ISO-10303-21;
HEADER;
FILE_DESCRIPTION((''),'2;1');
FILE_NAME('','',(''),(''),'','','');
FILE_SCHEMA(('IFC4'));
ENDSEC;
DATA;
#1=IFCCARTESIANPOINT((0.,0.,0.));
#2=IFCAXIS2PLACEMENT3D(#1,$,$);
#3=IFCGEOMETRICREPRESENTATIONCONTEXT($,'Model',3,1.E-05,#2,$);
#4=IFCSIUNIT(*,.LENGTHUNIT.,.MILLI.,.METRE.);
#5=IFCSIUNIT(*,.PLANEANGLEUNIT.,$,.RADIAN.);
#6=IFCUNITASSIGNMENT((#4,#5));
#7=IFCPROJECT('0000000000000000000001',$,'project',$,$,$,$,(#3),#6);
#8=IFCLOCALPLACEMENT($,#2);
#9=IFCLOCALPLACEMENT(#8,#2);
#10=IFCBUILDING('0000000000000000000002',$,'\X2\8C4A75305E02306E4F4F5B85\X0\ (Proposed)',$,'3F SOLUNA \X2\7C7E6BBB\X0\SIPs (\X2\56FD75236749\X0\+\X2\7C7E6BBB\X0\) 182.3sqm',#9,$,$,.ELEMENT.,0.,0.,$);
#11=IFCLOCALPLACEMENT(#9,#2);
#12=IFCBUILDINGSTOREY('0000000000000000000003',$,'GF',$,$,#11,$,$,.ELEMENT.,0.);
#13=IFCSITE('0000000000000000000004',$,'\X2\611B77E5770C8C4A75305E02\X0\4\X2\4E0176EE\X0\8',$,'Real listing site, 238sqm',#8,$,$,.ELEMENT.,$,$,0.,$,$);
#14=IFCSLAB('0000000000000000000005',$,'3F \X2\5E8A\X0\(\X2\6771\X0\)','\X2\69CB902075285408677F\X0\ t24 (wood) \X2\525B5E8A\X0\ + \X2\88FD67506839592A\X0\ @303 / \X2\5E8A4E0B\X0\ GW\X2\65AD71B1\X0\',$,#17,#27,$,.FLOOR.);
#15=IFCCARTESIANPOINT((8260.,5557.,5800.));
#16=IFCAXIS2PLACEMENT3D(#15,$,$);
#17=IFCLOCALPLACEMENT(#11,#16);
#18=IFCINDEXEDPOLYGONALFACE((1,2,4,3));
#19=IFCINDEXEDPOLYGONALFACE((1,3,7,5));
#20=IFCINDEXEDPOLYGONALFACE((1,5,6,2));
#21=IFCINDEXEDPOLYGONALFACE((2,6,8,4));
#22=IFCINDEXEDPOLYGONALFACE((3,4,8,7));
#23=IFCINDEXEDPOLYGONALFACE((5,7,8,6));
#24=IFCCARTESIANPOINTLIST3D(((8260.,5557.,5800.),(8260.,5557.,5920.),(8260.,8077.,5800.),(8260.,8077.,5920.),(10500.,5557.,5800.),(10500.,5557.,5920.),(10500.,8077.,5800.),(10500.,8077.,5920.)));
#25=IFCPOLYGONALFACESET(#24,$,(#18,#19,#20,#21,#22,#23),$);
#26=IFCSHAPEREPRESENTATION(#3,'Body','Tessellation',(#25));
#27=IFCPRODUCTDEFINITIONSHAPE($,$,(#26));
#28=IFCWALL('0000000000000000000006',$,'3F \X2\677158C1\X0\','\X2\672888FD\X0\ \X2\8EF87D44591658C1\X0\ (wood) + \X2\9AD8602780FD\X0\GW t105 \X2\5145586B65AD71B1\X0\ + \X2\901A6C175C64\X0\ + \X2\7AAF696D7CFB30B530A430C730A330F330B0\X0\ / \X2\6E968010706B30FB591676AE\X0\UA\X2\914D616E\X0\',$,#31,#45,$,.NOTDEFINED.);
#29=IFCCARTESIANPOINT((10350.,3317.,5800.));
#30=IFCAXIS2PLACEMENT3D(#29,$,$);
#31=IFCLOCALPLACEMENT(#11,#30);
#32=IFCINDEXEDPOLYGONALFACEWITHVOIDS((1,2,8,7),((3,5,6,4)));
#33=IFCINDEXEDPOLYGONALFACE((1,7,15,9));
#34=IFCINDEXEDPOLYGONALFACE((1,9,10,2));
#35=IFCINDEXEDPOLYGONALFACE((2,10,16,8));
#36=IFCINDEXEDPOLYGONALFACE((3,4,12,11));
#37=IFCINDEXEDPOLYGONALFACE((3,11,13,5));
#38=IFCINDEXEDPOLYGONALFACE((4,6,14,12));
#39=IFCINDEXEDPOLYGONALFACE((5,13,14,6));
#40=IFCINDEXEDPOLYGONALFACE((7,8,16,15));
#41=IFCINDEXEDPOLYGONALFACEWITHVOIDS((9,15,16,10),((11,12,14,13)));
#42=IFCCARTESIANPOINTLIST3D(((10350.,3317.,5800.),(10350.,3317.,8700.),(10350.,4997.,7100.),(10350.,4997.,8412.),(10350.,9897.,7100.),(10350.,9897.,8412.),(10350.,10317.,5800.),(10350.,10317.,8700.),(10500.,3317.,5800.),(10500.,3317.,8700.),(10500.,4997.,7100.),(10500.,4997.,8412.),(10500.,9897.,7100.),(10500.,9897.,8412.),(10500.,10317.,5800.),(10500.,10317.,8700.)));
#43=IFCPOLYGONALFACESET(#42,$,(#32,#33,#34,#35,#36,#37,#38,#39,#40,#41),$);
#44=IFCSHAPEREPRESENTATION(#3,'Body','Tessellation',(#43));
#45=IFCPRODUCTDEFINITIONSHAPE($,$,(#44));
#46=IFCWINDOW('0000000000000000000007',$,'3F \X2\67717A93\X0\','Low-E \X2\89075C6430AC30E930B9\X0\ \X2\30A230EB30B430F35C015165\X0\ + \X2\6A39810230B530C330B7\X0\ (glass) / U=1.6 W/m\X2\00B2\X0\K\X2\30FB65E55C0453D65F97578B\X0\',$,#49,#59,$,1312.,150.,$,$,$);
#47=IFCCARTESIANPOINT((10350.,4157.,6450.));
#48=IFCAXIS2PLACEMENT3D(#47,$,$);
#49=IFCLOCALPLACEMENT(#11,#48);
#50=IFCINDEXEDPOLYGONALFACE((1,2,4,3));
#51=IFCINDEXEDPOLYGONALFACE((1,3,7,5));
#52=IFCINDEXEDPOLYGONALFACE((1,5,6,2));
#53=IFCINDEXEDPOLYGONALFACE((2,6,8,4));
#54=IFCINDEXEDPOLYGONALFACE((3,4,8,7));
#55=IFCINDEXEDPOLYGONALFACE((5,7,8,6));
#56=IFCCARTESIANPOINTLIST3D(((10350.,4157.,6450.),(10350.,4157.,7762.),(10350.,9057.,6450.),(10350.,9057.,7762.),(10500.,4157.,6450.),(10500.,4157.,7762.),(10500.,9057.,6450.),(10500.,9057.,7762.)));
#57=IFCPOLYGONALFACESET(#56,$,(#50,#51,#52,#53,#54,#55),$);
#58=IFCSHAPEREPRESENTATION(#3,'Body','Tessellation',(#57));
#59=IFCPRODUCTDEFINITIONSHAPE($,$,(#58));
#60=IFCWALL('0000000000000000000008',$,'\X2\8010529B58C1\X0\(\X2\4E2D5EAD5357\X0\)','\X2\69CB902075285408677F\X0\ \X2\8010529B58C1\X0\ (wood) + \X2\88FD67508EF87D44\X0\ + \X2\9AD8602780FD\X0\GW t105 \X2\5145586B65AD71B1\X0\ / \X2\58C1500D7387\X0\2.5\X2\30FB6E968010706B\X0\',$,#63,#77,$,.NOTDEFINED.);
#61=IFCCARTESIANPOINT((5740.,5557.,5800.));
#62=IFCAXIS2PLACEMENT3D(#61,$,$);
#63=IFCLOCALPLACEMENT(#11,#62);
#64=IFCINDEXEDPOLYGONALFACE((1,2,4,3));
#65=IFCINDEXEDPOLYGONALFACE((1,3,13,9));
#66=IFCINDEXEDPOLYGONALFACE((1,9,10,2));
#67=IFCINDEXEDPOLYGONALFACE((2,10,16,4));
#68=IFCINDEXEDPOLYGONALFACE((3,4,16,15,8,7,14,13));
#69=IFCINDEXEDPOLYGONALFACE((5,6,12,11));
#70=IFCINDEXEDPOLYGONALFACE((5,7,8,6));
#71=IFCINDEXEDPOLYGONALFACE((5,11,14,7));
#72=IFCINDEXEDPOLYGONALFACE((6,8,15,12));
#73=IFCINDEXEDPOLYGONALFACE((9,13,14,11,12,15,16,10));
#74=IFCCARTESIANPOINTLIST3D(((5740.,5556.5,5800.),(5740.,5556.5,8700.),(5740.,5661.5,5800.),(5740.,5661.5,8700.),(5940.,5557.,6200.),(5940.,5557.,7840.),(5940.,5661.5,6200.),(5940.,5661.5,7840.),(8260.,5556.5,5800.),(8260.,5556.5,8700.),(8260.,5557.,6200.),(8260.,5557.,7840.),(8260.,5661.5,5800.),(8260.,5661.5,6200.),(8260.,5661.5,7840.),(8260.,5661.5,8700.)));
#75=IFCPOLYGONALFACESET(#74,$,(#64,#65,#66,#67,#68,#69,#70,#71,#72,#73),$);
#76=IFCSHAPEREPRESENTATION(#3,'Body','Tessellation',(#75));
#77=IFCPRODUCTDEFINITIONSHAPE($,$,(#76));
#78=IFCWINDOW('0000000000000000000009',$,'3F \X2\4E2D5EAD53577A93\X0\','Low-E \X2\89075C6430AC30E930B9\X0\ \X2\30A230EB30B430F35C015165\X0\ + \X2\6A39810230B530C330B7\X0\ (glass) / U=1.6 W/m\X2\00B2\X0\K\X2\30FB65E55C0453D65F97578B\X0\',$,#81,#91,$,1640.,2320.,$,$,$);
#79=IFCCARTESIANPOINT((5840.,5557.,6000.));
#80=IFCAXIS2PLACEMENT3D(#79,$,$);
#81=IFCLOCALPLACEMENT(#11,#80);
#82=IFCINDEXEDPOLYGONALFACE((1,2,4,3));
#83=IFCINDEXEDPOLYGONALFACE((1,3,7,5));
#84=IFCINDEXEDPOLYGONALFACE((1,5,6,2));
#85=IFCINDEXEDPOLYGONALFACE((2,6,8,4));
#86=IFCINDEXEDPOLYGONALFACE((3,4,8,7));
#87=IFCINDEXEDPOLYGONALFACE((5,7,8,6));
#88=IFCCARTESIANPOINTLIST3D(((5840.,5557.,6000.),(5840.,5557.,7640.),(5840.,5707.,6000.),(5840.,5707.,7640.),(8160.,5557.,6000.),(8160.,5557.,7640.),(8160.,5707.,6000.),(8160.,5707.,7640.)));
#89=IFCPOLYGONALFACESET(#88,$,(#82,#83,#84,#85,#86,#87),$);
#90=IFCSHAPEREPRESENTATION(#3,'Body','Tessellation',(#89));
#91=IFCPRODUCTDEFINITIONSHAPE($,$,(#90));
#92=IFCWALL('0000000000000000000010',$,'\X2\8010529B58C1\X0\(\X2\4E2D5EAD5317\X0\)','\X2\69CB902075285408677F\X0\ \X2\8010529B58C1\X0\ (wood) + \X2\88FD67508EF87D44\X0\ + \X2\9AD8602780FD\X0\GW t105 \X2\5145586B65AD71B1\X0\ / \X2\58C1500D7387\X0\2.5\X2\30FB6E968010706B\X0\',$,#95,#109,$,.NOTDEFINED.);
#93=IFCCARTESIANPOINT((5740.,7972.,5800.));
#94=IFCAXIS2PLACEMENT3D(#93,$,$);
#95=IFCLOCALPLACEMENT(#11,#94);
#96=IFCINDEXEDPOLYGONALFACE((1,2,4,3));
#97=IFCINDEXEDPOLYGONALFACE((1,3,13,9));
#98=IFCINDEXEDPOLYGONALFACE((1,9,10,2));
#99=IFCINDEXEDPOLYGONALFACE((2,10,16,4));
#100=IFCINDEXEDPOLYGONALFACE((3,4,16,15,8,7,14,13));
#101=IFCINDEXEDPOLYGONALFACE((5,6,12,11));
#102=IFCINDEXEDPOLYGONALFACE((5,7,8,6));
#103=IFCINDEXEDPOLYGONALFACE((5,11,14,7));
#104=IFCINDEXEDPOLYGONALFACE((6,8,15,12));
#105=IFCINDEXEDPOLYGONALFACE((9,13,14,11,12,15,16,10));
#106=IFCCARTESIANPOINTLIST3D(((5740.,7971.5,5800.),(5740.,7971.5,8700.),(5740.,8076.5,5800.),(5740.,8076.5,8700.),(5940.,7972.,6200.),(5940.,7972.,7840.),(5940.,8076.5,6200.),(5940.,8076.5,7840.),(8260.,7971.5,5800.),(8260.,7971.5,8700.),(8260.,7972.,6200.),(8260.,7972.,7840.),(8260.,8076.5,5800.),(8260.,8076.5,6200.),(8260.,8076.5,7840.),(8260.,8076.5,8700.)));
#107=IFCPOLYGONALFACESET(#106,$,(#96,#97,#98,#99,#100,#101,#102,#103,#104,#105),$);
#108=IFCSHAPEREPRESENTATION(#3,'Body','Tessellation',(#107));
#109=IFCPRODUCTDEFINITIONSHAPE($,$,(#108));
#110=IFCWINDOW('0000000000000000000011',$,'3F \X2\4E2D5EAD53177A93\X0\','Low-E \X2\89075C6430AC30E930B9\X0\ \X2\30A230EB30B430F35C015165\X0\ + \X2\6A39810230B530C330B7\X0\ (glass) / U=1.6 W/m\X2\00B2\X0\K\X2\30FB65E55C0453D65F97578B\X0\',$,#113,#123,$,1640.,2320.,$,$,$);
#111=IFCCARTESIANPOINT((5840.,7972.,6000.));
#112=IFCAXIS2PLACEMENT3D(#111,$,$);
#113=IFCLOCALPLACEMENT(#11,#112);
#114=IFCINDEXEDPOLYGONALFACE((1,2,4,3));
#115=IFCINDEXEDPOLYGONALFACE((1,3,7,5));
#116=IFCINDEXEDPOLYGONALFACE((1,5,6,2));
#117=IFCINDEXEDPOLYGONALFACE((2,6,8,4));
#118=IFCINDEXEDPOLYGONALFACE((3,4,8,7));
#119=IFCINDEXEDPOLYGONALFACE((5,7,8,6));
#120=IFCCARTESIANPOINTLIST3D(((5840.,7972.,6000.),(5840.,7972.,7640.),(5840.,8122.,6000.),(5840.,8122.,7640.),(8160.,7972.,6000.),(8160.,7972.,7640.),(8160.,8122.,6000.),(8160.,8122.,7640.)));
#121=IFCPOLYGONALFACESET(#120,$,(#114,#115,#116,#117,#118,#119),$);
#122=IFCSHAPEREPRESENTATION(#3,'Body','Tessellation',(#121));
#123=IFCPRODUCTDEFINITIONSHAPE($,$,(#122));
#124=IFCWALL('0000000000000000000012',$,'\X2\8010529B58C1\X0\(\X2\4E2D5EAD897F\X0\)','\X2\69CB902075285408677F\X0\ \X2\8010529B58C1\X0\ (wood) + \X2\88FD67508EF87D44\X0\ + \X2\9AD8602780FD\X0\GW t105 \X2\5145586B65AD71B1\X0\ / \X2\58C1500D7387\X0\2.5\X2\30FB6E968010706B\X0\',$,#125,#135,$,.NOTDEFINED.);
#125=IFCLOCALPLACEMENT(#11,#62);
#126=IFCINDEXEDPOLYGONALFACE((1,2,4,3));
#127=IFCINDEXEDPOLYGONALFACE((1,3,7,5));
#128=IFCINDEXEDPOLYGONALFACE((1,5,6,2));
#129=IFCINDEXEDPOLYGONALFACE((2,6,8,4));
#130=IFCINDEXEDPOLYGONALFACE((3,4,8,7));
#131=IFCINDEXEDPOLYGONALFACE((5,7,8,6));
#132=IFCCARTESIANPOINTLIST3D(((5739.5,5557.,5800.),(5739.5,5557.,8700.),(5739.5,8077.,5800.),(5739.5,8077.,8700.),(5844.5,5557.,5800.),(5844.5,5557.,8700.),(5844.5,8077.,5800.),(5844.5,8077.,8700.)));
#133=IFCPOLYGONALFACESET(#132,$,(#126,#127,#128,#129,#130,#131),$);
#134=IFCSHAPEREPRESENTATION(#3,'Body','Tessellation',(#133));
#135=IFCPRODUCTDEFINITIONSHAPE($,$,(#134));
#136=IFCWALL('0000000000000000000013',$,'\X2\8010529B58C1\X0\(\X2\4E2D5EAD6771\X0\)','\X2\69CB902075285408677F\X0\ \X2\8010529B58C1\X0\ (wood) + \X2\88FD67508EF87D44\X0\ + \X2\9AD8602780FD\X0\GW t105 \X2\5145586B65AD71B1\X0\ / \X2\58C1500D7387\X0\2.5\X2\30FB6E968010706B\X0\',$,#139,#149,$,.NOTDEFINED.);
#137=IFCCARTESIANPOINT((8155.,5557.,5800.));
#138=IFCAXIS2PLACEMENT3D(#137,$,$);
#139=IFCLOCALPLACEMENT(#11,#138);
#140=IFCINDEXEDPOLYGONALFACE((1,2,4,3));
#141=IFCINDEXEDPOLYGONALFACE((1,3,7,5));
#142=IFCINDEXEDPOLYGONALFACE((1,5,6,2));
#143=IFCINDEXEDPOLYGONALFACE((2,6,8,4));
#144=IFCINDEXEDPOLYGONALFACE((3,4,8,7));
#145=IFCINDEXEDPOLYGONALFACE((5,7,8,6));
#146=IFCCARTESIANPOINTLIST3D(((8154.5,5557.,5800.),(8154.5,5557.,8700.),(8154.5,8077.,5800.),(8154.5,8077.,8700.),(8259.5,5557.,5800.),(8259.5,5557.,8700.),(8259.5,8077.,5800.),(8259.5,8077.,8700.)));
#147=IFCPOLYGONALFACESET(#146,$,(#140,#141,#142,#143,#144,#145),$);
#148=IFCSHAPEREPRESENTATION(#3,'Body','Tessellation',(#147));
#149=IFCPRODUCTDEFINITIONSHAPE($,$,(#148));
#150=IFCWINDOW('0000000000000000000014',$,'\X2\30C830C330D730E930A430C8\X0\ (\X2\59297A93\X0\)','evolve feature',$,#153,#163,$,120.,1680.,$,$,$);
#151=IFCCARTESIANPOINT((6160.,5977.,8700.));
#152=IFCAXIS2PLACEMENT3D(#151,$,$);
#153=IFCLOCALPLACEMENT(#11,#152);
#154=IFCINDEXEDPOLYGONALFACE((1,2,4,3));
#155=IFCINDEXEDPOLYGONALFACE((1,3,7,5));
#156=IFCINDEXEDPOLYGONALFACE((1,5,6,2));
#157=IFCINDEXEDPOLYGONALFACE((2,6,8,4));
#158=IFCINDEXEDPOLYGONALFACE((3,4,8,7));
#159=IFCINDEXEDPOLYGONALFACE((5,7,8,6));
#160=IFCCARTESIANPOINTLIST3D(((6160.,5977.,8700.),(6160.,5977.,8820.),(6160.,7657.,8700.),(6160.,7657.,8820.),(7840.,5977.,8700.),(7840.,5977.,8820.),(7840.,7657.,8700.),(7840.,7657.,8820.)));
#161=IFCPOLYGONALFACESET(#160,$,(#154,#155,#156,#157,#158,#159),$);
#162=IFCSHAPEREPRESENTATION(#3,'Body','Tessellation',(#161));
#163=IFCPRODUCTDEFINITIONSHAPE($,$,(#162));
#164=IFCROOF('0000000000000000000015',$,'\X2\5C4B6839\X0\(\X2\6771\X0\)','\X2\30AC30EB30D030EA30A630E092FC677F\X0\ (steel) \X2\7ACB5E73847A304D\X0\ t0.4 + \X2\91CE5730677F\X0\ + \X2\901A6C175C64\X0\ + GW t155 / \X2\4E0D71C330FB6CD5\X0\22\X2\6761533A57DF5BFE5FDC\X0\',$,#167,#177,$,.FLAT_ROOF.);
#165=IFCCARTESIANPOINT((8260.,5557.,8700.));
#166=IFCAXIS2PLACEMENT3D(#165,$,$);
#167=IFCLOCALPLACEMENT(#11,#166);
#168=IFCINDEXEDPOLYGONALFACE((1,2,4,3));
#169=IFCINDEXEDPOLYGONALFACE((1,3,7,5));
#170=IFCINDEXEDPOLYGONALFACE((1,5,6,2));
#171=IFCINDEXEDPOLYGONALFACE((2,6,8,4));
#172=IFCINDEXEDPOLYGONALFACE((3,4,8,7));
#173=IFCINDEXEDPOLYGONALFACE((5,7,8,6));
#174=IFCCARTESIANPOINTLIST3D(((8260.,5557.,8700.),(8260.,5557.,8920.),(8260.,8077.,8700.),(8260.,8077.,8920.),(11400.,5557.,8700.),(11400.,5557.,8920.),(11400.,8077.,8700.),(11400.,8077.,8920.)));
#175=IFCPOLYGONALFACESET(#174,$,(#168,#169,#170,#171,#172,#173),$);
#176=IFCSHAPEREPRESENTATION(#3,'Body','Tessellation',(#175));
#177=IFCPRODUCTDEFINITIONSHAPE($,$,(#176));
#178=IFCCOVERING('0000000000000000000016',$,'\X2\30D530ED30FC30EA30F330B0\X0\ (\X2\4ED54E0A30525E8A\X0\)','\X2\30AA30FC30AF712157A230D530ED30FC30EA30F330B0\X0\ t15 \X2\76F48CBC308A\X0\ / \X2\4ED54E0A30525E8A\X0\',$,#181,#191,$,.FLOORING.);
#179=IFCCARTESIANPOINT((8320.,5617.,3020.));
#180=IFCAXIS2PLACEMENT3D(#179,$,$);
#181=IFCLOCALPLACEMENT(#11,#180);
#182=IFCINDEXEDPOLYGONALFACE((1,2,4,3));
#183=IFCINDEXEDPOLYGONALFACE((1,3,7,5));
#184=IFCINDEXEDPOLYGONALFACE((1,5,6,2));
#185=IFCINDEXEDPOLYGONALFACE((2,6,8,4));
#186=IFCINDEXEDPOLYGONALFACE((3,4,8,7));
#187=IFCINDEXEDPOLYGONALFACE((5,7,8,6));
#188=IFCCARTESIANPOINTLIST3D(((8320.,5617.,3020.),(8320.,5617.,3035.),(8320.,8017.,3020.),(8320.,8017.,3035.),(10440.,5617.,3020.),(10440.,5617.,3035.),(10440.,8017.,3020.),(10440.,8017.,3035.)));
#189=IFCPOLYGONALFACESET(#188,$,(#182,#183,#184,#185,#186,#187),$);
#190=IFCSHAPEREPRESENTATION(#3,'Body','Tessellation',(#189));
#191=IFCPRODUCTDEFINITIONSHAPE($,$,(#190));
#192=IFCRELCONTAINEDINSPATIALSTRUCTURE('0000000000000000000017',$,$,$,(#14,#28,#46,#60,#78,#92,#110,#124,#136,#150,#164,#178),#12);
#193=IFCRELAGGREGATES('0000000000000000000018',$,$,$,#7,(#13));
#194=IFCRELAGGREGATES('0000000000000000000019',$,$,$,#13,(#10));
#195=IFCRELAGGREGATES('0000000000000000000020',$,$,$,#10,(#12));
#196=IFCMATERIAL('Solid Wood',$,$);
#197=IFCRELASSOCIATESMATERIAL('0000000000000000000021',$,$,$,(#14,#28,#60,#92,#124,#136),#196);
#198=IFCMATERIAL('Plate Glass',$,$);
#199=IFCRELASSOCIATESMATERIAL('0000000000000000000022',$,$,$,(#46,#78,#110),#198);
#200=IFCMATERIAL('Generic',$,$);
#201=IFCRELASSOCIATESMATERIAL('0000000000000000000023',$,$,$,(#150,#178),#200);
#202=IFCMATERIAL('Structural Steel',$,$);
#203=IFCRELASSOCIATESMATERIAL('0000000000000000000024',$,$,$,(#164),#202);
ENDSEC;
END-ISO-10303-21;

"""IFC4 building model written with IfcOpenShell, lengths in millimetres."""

from ifc_helpers import new_model, si_unit, frame, frame_2d, origin, place, context, project, spatial, rectangle, extrude, material, element, fill, save


model = new_model("IFC4")

# Units and contexts
model_context = context("Model", 3, precision=1e-05, world=origin())
ifc_project = project(units=[si_unit("LENGTHUNIT", "METRE", prefix="MILLI"), si_unit("PLANEANGLEUNIT", "RADIAN")], contexts=[model_context])

# Site, building, storey
site_placement = place(None, origin())
site = spatial("IfcSite", under=ifc_project, at=site_placement, Name="愛知県豊田市4丁目8", ObjectType="Real listing site, 238sqm", CompositionType="ELEMENT", RefElevation=0.0)
building_placement = place(site_placement, origin())
building = spatial("IfcBuilding", under=site, at=building_placement, Name="豊田市の住宅 (Proposed)", ObjectType="3F SOLUNA 籾殻SIPs (国産杉+籾殻) 182.3sqm", CompositionType="ELEMENT", ElevationOfRefHeight=0.0, ElevationOfTerrain=0.0)
storey_placement = place(building_placement, origin())
storey = spatial("IfcBuildingStorey", under=building, at=storey_placement, Name="GF", CompositionType="ELEMENT", Elevation=0.0)

# Slab
ifc_material_1 = material(Name="Solid Wood")
slab_placement = place(storey_placement, frame((8260.0, 5557.0, 5800.0)))
element("IfcSlab", 1, at=slab_placement, inside=storey, material=ifc_material_1, Name="3F 床(東)", Description="構造用合板 t24 (wood) 剛床 + 製材根太 @303 / 床下 GW断熱", PredefinedType="FLOOR", context=model_context, shape_type="SweptSolid", body=[
    extrude(rectangle(XDim=2240.0, YDim=2520.0, at=frame_2d((1120.0, 1260.0))), frame((8260.0, 5557.0, 5800.0)), (0.0, 0.0, 1.0), 120.0),
])

# Walls, openings, windows
wall_1_placement = place(storey_placement, frame((10350.0, 3317.0, 5800.0)))
wall_1 = element("IfcWall", 2, at=wall_1_placement, inside=storey, material=ifc_material_1, Name="3F 東壁", Description="木製 軸組外壁 (wood) + 高性能GW t105 充填断熱 + 通気層 + 窯業系サイディング / 準耐火・外皮UA配慮", PredefinedType="NOTDEFINED", context=model_context, shape_type="SweptSolid", body=[
    extrude(rectangle(XDim=150.0, YDim=7000.0, at=frame_2d((75.0, 3500.0))), frame((10350.0, 3317.0, 5800.0)), (0.0, 0.0, 1.0), 2900.0),
])
opening_1_placement = place(storey_placement, frame((10350.0, 4157.0, 6450.0)))
opening_1 = element("IfcOpeningElement", 3, at=opening_1_placement, cuts=wall_1, PredefinedType="NOTDEFINED", context=model_context, shape_type="SweptSolid", body=[
    extrude(rectangle(XDim=150.0, YDim=4900.0, at=frame_2d((75.0, 2450.0))), frame((10350.0, 4157.0, 6450.0)), (0.0, 0.0, 1.0), 1312.0),
])
ifc_material_2 = material(Name="Plate Glass")
window_1_placement = place(storey_placement, frame((10350.0, 4157.0, 6450.0)))
window_1 = element("IfcWindow", 4, at=window_1_placement, inside=storey, material=ifc_material_2, Name="3F 東窓", Description="Low-E 複層ガラス アルゴン封入 + 樹脂サッシ (glass) / U=1.6 W/m²K・日射取得型", OverallHeight=1312.0, OverallWidth=150.0, context=model_context, shape_type="SweptSolid", body=[
    extrude(rectangle(XDim=150.0, YDim=4900.0, at=frame_2d((75.0, 2450.0))), frame((10350.0, 4157.0, 6450.0)), (0.0, 0.0, 1.0), 1312.0),
])
fill(opening_1, window_1)
wall_2_placement = place(storey_placement, frame((5740.0, 5557.0, 5800.0)))
wall_2 = element("IfcWall", 5, at=wall_2_placement, inside=storey, material=ifc_material_1, Name="耐力壁(中庭南)", Description="構造用合板 耐力壁 (wood) + 製材軸組 + 高性能GW t105 充填断熱 / 壁倍率2.5・準耐火", PredefinedType="NOTDEFINED", context=model_context, shape_type="SweptSolid", body=[
    extrude(rectangle(XDim=2520.0, YDim=105.0, at=frame_2d((1260.0, 52.0))), frame((5740.0, 5557.0, 5800.0)), (0.0, 0.0, 1.0), 2900.0),
])
opening_2_placement = place(storey_placement, frame((5840.0, 5557.0, 6000.0)))
opening_2 = element("IfcOpeningElement", 6, at=opening_2_placement, cuts=wall_2, PredefinedType="NOTDEFINED", context=model_context, shape_type="SweptSolid", body=[
    extrude(rectangle(XDim=2320.0, YDim=150.0, at=frame_2d((1160.0, 75.0))), frame((5840.0, 5557.0, 6000.0)), (0.0, 0.0, 1.0), 1640.0),
])
window_2_placement = place(storey_placement, frame((5840.0, 5557.0, 6000.0)))
window_2 = element("IfcWindow", 7, at=window_2_placement, inside=storey, material=ifc_material_2, Name="3F 中庭南窓", Description="Low-E 複層ガラス アルゴン封入 + 樹脂サッシ (glass) / U=1.6 W/m²K・日射取得型", OverallHeight=1640.0, OverallWidth=2320.0, context=model_context, shape_type="SweptSolid", body=[
    extrude(rectangle(XDim=2320.0, YDim=150.0, at=frame_2d((1160.0, 75.0))), frame((5840.0, 5557.0, 6000.0)), (0.0, 0.0, 1.0), 1640.0),
])
fill(opening_2, window_2)
wall_3_placement = place(storey_placement, frame((5740.0, 7972.0, 5800.0)))
wall_3 = element("IfcWall", 8, at=wall_3_placement, inside=storey, material=ifc_material_1, Name="耐力壁(中庭北)", Description="構造用合板 耐力壁 (wood) + 製材軸組 + 高性能GW t105 充填断熱 / 壁倍率2.5・準耐火", PredefinedType="NOTDEFINED", context=model_context, shape_type="SweptSolid", body=[
    extrude(rectangle(XDim=2520.0, YDim=105.0, at=frame_2d((1260.0, 52.0))), frame((5740.0, 7972.0, 5800.0)), (0.0, 0.0, 1.0), 2900.0),
])
opening_3_placement = place(storey_placement, frame((5840.0, 7972.0, 6000.0)))
opening_3 = element("IfcOpeningElement", 9, at=opening_3_placement, cuts=wall_3, PredefinedType="NOTDEFINED", context=model_context, shape_type="SweptSolid", body=[
    extrude(rectangle(XDim=2320.0, YDim=150.0, at=frame_2d((1160.0, 75.0))), frame((5840.0, 7972.0, 6000.0)), (0.0, 0.0, 1.0), 1640.0),
])
window_3_placement = place(storey_placement, frame((5840.0, 7972.0, 6000.0)))
window_3 = element("IfcWindow", 10, at=window_3_placement, inside=storey, material=ifc_material_2, Name="3F 中庭北窓", Description="Low-E 複層ガラス アルゴン封入 + 樹脂サッシ (glass) / U=1.6 W/m²K・日射取得型", OverallHeight=1640.0, OverallWidth=2320.0, context=model_context, shape_type="SweptSolid", body=[
    extrude(rectangle(XDim=2320.0, YDim=150.0, at=frame_2d((1160.0, 75.0))), frame((5840.0, 7972.0, 6000.0)), (0.0, 0.0, 1.0), 1640.0),
])
fill(opening_3, window_3)

# Walls
wall_4_placement = place(storey_placement, frame((5740.0, 5557.0, 5800.0)))
element("IfcWall", 11, at=wall_4_placement, inside=storey, material=ifc_material_1, Name="耐力壁(中庭西)", Description="構造用合板 耐力壁 (wood) + 製材軸組 + 高性能GW t105 充填断熱 / 壁倍率2.5・準耐火", PredefinedType="NOTDEFINED", context=model_context, shape_type="SweptSolid", body=[
    extrude(rectangle(XDim=105.0, YDim=2520.0, at=frame_2d((52.0, 1260.0))), frame((5740.0, 5557.0, 5800.0)), (0.0, 0.0, 1.0), 2900.0),
])
wall_5_placement = place(storey_placement, frame((8155.0, 5557.0, 5800.0)))
element("IfcWall", 12, at=wall_5_placement, inside=storey, material=ifc_material_1, Name="耐力壁(中庭東)", Description="構造用合板 耐力壁 (wood) + 製材軸組 + 高性能GW t105 充填断熱 / 壁倍率2.5・準耐火", PredefinedType="NOTDEFINED", context=model_context, shape_type="SweptSolid", body=[
    extrude(rectangle(XDim=105.0, YDim=2520.0, at=frame_2d((52.0, 1260.0))), frame((8155.0, 5557.0, 5800.0)), (0.0, 0.0, 1.0), 2900.0),
])

# Window
ifc_material_3 = material(Name="Generic")
window_4_placement = place(storey_placement, frame((6160.0, 5977.0, 8700.0)))
element("IfcWindow", 13, at=window_4_placement, inside=storey, material=ifc_material_3, Name="トップライト (天窓)", Description="evolve feature", OverallHeight=120.0, OverallWidth=1680.0, context=model_context, shape_type="SweptSolid", body=[
    extrude(rectangle(XDim=1680.0, YDim=1680.0, at=frame_2d((840.0, 840.0))), frame((6160.0, 5977.0, 8700.0)), (0.0, 0.0, 1.0), 120.0),
])

# Roof
ifc_material_4 = material(Name="Structural Steel")
for number, where, name in (
    (14, (8260.0, 5557.0, 8700.0), "屋根(東)"),
):
    element("IfcRoof", number, at=place(storey_placement, frame(where)), inside=storey, material=ifc_material_4, Name=name, Description="ガルバリウム鋼板 (steel) 立平葺き t0.4 + 野地板 + 通気層 + GW t155 / 不燃・法22条区域対応", PredefinedType="FLAT_ROOF", context=model_context, shape_type="SweptSolid", body=[
        extrude(rectangle(XDim=3140.0, YDim=2520.0, at=frame_2d((1570.0, 1260.0))), frame((8260.0, 5557.0, 8700.0)), (0.0, 0.0, 1.0), 220.0),
    ])

# Covering
covering_1_placement = place(storey_placement, frame((8320.0, 5617.0, 3020.0)))
element("IfcCovering", 15, at=covering_1_placement, inside=storey, material=ifc_material_3, Name="フローリング (仕上げ床)", Description="オーク無垢フローリング t15 直貼り / 仕上げ床", PredefinedType="FLOORING", context=model_context, shape_type="SweptSolid", body=[
    extrude(rectangle(XDim=2120.0, YDim=2400.0, at=frame_2d((1060.0, 1200.0))), frame((8320.0, 5617.0, 3020.0)), (0.0, 0.0, 1.0), 15.0),
])

save(model, "model.ifc")
